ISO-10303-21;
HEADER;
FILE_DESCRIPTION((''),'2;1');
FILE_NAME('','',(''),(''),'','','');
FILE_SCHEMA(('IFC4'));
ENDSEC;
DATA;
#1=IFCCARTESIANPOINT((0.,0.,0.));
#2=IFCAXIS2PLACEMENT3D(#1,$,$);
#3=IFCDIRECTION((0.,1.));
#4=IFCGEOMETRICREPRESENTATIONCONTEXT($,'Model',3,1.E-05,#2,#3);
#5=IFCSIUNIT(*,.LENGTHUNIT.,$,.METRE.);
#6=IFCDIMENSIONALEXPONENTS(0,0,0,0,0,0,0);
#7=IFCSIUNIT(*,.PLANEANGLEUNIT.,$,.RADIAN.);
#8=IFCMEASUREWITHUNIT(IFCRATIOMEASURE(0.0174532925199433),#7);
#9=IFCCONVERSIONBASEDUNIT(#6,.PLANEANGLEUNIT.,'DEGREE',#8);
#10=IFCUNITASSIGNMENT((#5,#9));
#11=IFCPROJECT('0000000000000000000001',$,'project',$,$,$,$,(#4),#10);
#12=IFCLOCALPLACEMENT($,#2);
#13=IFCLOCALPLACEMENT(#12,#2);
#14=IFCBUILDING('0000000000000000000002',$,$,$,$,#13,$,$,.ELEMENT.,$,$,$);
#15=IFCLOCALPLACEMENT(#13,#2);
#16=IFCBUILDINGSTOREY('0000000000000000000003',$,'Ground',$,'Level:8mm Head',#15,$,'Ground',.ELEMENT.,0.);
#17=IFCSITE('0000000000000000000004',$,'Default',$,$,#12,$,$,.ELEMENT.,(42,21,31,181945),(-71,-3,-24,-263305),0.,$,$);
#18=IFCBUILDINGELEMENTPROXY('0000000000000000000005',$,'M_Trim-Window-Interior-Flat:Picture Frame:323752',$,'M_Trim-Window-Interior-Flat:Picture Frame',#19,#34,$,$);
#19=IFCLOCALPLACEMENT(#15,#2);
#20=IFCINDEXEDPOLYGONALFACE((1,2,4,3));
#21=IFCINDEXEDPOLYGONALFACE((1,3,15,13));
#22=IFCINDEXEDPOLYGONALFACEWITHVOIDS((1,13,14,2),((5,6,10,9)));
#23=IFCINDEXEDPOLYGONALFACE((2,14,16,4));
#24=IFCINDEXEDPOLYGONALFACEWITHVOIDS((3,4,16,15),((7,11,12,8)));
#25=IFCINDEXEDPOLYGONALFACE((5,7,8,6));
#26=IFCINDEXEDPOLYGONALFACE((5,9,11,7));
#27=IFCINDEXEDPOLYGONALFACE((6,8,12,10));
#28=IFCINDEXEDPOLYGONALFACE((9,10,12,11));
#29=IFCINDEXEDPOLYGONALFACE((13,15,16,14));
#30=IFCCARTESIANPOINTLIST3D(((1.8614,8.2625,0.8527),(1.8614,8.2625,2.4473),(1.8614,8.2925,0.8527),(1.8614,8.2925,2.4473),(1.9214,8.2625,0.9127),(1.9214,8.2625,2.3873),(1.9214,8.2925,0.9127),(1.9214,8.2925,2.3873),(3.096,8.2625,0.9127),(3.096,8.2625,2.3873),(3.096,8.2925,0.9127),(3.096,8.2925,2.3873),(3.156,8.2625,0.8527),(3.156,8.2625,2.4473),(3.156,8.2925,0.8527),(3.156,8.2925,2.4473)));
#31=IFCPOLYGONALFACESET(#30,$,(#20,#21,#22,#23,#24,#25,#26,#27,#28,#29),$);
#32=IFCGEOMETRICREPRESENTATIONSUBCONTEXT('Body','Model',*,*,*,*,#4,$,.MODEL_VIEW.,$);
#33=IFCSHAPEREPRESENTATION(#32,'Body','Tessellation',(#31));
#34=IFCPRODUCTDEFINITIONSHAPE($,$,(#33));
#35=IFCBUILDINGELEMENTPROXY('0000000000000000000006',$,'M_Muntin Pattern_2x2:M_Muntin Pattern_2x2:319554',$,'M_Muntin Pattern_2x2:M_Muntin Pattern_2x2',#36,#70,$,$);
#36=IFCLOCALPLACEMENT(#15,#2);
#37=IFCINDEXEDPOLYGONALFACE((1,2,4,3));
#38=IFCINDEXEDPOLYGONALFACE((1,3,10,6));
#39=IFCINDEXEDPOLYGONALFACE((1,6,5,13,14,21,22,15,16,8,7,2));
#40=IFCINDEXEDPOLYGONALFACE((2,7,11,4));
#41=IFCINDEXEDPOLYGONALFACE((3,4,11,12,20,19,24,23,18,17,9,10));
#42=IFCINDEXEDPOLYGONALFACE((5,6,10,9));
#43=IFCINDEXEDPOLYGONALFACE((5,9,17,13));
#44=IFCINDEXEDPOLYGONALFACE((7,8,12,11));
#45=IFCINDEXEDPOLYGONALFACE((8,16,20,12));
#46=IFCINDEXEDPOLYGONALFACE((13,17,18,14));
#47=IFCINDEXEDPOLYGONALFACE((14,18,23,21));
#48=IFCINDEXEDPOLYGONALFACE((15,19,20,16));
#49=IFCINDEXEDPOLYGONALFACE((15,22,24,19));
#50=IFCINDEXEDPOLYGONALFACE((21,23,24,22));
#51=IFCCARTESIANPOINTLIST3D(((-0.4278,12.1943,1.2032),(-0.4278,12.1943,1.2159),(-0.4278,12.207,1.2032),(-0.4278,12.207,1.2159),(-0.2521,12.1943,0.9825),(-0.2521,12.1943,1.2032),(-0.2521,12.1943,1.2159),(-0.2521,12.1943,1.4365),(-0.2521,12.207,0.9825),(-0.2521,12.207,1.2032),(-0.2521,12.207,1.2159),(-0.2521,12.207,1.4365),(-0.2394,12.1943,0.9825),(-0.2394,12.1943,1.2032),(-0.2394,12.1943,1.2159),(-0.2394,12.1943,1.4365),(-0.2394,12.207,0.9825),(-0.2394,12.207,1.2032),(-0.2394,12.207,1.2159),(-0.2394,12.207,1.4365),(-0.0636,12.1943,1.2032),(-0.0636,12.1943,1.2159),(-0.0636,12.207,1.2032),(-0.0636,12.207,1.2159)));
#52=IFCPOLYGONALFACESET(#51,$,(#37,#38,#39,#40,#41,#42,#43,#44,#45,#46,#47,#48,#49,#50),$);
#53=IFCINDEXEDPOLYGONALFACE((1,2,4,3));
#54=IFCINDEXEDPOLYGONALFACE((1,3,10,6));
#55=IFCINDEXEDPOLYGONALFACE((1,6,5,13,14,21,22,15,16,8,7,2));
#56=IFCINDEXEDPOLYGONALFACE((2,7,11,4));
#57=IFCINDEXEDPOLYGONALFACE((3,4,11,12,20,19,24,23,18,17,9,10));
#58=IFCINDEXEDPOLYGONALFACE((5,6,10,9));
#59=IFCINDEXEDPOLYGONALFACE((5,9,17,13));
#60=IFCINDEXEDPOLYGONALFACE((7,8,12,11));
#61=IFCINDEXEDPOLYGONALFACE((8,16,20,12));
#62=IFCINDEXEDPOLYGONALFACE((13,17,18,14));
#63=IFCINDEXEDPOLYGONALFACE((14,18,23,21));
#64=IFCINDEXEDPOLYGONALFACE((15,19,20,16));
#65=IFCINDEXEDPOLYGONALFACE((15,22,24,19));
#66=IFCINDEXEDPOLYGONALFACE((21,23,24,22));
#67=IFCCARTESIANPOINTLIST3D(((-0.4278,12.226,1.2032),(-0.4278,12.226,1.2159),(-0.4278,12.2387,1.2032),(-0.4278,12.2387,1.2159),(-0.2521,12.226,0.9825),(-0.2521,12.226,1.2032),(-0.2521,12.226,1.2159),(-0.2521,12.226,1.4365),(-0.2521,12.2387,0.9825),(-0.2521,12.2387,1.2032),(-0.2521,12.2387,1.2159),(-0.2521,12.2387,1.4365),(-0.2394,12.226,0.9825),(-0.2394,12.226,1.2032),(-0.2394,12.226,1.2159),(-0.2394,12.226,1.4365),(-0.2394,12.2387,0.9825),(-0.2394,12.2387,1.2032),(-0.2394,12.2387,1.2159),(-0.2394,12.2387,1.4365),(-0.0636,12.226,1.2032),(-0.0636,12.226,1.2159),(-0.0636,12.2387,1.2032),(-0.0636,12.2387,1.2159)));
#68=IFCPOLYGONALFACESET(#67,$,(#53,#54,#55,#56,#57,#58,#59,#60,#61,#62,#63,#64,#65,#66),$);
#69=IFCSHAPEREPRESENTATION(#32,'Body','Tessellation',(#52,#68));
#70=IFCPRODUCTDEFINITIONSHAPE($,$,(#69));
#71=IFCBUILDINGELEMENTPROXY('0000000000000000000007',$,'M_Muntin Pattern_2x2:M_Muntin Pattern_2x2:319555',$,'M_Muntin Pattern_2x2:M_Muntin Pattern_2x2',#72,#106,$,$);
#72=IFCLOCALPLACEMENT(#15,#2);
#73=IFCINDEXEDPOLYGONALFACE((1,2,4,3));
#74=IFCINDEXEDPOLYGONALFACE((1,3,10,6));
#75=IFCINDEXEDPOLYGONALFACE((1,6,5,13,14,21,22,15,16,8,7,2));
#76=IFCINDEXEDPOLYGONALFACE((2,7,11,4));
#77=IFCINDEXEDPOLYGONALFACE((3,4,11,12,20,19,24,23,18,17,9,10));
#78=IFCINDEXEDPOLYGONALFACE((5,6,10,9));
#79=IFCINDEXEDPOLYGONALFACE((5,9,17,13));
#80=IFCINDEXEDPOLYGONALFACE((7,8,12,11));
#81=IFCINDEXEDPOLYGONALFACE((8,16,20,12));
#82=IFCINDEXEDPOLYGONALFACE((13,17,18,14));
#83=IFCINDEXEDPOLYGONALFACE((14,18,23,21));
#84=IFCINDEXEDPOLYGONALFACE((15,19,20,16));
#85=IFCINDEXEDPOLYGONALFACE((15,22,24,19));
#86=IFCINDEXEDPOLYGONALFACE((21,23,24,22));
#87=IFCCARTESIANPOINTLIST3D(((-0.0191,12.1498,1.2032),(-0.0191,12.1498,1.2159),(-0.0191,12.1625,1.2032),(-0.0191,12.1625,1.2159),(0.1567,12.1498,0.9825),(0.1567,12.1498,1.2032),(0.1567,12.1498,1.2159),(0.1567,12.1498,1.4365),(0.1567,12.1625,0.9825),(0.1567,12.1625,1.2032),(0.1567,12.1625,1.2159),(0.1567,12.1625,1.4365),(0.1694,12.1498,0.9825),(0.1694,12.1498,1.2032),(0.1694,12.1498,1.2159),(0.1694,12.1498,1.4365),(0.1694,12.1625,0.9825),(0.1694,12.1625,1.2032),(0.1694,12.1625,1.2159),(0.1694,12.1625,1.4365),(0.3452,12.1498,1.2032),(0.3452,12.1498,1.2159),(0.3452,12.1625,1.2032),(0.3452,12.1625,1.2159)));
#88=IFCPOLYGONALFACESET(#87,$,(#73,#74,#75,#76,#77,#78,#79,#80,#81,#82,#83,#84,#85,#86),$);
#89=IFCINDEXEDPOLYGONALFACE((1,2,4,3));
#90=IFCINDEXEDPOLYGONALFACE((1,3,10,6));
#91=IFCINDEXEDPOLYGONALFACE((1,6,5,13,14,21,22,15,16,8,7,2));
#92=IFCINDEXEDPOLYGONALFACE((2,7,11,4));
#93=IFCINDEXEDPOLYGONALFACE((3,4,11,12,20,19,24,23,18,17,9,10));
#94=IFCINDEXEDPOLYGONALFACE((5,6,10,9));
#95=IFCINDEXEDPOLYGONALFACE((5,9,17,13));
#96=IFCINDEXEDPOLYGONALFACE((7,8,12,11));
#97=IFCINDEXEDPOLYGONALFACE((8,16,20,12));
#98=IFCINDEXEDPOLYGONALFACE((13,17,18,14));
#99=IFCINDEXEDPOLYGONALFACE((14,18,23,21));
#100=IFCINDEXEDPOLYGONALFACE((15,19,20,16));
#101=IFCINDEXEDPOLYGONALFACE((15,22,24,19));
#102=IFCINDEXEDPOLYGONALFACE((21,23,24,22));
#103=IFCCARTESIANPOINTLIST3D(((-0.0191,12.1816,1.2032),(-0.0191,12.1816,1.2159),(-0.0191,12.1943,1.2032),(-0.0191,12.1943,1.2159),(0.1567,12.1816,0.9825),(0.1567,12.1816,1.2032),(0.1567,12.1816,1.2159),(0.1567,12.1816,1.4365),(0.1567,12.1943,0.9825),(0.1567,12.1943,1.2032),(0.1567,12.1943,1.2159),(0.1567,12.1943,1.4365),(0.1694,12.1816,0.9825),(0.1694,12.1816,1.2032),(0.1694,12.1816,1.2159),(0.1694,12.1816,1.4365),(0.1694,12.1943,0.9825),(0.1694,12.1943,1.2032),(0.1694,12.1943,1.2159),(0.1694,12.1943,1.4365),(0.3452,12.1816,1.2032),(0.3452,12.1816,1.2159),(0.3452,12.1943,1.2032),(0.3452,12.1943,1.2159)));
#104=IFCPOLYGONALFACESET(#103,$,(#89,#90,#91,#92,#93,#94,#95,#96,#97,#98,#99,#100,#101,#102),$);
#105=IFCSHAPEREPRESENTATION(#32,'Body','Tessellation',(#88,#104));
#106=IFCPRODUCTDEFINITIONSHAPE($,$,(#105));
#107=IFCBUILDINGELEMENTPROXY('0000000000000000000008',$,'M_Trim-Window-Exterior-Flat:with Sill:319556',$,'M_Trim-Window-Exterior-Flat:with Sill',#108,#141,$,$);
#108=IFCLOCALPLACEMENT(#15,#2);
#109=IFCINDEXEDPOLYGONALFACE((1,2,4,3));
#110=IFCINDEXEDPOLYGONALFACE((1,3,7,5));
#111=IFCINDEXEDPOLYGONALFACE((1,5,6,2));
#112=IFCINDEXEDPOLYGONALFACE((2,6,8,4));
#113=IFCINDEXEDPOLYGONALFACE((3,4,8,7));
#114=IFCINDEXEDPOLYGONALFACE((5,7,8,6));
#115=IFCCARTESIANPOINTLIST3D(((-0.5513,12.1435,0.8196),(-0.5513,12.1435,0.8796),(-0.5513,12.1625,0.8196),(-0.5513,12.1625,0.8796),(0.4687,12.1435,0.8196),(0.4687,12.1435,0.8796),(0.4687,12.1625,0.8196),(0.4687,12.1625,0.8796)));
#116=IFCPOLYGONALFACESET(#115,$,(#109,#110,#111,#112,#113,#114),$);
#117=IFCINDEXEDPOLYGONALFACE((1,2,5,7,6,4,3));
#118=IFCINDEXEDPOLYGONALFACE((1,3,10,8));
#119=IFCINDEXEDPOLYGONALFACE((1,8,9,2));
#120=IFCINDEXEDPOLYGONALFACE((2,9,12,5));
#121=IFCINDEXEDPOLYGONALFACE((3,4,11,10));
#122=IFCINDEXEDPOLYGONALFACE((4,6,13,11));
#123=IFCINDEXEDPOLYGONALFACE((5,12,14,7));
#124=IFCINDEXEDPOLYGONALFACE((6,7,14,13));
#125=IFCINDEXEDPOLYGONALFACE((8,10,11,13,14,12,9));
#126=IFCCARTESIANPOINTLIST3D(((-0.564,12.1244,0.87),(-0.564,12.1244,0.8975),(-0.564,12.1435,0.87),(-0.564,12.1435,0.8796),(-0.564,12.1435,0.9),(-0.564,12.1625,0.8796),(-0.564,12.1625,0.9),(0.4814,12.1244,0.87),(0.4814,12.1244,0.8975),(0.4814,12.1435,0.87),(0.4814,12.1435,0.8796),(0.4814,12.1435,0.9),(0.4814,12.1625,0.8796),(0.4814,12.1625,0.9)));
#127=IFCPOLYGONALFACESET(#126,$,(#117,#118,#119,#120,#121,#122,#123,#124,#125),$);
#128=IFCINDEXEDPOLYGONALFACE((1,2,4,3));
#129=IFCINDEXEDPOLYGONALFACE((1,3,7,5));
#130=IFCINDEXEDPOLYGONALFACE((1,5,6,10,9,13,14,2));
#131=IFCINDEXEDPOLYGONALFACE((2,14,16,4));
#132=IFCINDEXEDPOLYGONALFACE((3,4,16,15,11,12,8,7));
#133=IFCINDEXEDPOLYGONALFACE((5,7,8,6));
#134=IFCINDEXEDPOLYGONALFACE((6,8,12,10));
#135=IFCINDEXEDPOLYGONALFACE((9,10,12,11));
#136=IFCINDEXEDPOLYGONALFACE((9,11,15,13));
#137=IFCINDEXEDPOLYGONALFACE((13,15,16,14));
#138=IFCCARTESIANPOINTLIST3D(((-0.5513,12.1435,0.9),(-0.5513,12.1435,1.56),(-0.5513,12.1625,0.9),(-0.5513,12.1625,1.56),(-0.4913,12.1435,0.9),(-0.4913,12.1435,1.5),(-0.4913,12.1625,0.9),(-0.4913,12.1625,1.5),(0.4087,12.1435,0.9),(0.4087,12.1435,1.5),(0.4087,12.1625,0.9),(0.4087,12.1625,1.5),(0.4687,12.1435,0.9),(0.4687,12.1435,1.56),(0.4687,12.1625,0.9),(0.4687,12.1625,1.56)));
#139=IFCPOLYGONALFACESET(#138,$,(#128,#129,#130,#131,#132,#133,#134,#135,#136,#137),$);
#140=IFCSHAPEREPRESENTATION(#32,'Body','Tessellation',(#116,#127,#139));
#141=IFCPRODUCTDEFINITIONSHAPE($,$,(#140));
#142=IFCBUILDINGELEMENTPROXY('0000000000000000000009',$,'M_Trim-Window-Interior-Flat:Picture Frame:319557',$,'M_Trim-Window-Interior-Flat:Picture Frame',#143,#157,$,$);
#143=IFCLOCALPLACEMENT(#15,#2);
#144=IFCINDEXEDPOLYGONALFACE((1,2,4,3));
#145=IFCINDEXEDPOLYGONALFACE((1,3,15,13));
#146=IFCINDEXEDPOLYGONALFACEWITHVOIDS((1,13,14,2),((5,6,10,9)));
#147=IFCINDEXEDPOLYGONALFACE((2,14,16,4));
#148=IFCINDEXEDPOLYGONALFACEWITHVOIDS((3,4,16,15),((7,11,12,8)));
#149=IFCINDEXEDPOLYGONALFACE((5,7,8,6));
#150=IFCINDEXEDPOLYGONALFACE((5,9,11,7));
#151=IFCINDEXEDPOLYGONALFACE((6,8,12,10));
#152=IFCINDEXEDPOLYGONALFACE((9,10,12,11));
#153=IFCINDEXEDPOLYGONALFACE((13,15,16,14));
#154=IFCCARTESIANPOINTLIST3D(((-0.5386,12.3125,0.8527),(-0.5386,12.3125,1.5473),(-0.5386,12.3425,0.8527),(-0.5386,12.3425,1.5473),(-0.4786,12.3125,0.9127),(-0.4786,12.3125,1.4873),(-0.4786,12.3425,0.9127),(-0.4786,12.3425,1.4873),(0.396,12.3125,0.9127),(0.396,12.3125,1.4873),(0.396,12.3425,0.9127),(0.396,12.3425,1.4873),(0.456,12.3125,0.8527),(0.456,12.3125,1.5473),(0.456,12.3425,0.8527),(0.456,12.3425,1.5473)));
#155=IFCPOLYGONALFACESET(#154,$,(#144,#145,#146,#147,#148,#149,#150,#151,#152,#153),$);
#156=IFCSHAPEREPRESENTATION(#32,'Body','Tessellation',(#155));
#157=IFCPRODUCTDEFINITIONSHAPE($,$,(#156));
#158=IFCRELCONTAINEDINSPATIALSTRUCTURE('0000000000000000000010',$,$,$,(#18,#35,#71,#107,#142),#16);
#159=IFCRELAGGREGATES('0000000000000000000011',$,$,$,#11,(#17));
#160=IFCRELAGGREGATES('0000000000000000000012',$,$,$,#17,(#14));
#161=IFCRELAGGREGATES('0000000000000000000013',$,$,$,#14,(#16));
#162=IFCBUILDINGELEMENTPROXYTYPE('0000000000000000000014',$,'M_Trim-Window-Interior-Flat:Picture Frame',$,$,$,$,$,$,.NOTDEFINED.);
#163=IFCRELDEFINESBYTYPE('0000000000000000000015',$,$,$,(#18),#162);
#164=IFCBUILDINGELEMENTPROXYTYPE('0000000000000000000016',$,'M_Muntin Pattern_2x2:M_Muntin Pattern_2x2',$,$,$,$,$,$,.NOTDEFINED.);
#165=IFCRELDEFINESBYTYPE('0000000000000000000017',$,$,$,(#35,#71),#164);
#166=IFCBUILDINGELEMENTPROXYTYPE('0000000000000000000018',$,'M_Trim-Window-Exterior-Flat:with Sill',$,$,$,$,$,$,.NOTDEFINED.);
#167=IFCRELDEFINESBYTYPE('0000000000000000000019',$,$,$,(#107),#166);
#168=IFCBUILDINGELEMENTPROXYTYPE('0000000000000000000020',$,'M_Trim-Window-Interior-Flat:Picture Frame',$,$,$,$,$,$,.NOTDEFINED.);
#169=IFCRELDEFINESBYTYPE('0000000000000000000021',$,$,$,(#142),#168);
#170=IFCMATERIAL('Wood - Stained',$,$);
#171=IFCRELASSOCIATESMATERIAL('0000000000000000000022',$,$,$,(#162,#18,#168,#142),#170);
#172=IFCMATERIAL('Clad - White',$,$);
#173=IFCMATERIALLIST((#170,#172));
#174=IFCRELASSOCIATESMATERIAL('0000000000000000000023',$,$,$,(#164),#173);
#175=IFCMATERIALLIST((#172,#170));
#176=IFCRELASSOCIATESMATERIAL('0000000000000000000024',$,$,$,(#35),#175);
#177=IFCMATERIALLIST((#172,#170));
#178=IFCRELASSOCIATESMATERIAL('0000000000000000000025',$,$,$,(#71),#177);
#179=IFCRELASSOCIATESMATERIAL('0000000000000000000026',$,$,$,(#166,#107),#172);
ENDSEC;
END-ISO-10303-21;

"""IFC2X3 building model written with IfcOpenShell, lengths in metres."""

from ifc_helpers import new_model, entity, si_unit, converted_unit, direction, frame, frame_2d, origin, place, context, subcontext, project, spatial, polyline, rectangle, outline, extrude, source, transform, mapped, material, material_list, type_object, type_shapes, element, save


model = new_model("IFC2X3")

# Units and contexts
model_context = context("Model", 3, precision=1e-05, world=origin(), true_north=direction((0.0, 1.0)))
body_context = subcontext(model_context, "Body", "Model", "MODEL_VIEW")
ifc_project = project(units=[si_unit("LENGTHUNIT", "METRE"), converted_unit("PLANEANGLEUNIT", "DEGREE", entity("IfcRatioMeasure", 0.0174532925199433), si_unit("PLANEANGLEUNIT", "RADIAN"), dimensions=[0, 0, 0, 0, 0, 0, 0])], contexts=[model_context])

# Site, building, storey
site_placement = place(None, origin())
site = spatial("IfcSite", under=ifc_project, at=site_placement, Name="Default", CompositionType="ELEMENT", RefLatitude=(42, 21, 31, 181945), RefLongitude=(-71, -3, -24, -263305), RefElevation=0.0)
building_placement = place(site_placement, origin())
building = spatial("IfcBuilding", under=site, at=building_placement, CompositionType="ELEMENT")
storey_placement = place(building_placement, origin())
storey = spatial("IfcBuildingStorey", under=building, at=storey_placement, Name="Ground", ObjectType="Level:8mm Head", LongName="Ground", CompositionType="ELEMENT", Elevation=0.0)

# Building element proxies
ifc_material_1 = material(Name="Clad - White")
ifc_material_2 = material(Name="Wood - Stained")
building_element_proxy_type_1 = type_object("IfcBuildingElementProxyType", Name="M_Trim-Window-Interior-Flat:Picture Frame", PredefinedType="NOTDEFINED", material=ifc_material_2)
shared_shape_1 = source(origin(), body_context, "Body", "SweptSolid", [
    extrude(outline(polyline([(-0.6473, -0.7973), (0.6473, -0.7973), (0.6473, 0.7973), (-0.6473, 0.7973), (-0.6473, -0.7973)]), holes=[polyline([(-0.5873, -0.7373), (-0.5873, 0.7373), (0.5873, 0.7373), (0.5873, -0.7373), (-0.5873, -0.7373)])]), frame((0.0, -0.75, 0.0), z_axis=(0.0, 0.0, 1.0), x_axis=(-1.0, 0.0, 0.0)), (0.0, 0.0, 1.0), 0.03),
])
type_shapes(building_element_proxy_type_1, [shared_shape_1])
for number, where, z_axis, x_axis, name in (
    (1, (2.5087, 8.2625, 2.4), (0.0, 1.0, 0.0), (-1.0, 0.0, 0.0), "M_Trim-Window-Interior-Flat:Picture Frame:323752"),
):
    element("IfcBuildingElementProxy", number, at=place(storey_placement, frame(where, z_axis=z_axis, x_axis=x_axis)), inside=storey, type_object=building_element_proxy_type_1, material=ifc_material_2, Name=name, ObjectType="M_Trim-Window-Interior-Flat:Picture Frame", context=body_context, shape_type="MappedRepresentation", body=[
        mapped(shared_shape_1, transform((0.0, 0.0, 0.0), scale=1.0)),
    ])
ifc_material_list_1 = material_list([ifc_material_1, ifc_material_2])
ifc_material_list_2 = material_list([ifc_material_2, ifc_material_1])
building_element_proxy_type_2 = type_object("IfcBuildingElementProxyType", Name="M_Muntin Pattern_2x2:M_Muntin Pattern_2x2", PredefinedType="NOTDEFINED", material=ifc_material_list_2)
shared_shape_2 = source(origin(), body_context, "Body", "SweptSolid", [
    extrude(outline(polyline([(0.0064, -0.0064), (0.227, -0.0064), (0.227, 0.0063), (0.0064, 0.0063), (0.0064, 0.1821), (-0.0063, 0.1821), (-0.0063, 0.0063), (-0.227, 0.0063), (-0.227, -0.0064), (-0.0063, -0.0064), (-0.0063, -0.1821), (0.0064, -0.1821), (0.0064, -0.0064)])), frame((0.0, 0.0095, 0.227), z_axis=(0.0, 1.0, 0.0), x_axis=(0.0, 0.0, 1.0)), (0.0, 0.0, 1.0), 0.0127),
    extrude(outline(polyline([(0.0064, -0.0064), (0.227, -0.0064), (0.227, 0.0063), (0.0064, 0.0063), (0.0064, 0.1821), (-0.0063, 0.1821), (-0.0063, 0.0063), (-0.227, 0.0063), (-0.227, -0.0064), (-0.0063, -0.0064), (-0.0063, -0.1821), (0.0064, -0.1821), (0.0064, -0.0064)])), frame((0.0, -0.0222, 0.227), z_axis=(0.0, 1.0, 0.0), x_axis=(0.0, 0.0, 1.0)), (0.0, 0.0, 1.0), 0.0127),
])
type_shapes(building_element_proxy_type_2, [shared_shape_2])
proxy_1_placement = place(storey_placement, frame((-0.2457, 12.2165, 0.9825), z_axis=(0.0, 0.0, 1.0), x_axis=(-1.0, 0.0, 0.0)))
element("IfcBuildingElementProxy", 2, at=proxy_1_placement, inside=storey, type_object=building_element_proxy_type_2, material=ifc_material_list_1, Name="M_Muntin Pattern_2x2:M_Muntin Pattern_2x2:319554", ObjectType="M_Muntin Pattern_2x2:M_Muntin Pattern_2x2", context=body_context, shape_type="MappedRepresentation", body=[
    mapped(shared_shape_2, transform((0.0, 0.0, 0.0), scale=1.0)),
])
ifc_material_list_3 = material_list([ifc_material_1, ifc_material_2])
proxy_2_placement = place(storey_placement, frame((0.163, 12.1721, 0.9825), z_axis=(0.0, 0.0, 1.0), x_axis=(-1.0, 0.0, 0.0)))
element("IfcBuildingElementProxy", 3, at=proxy_2_placement, inside=storey, type_object=building_element_proxy_type_2, material=ifc_material_list_3, Name="M_Muntin Pattern_2x2:M_Muntin Pattern_2x2:319555", ObjectType="M_Muntin Pattern_2x2:M_Muntin Pattern_2x2", context=body_context, shape_type="MappedRepresentation", body=[
    mapped(shared_shape_2, transform((0.0, 0.0, 0.0), scale=1.0)),
])
building_element_proxy_type_3 = type_object("IfcBuildingElementProxyType", Name="M_Trim-Window-Exterior-Flat:with Sill", PredefinedType="NOTDEFINED", material=ifc_material_1)
shared_shape_3 = source(origin(), body_context, "Body", "SweptSolid", [
    extrude(rectangle(XDim=1.02, YDim=0.06, at=frame_2d((0.0, 0.0), x_axis=(1.0, 0.0))), frame((0.0, -0.6504, 0.0), z_axis=(0.0, 0.0, 1.0), x_axis=(-1.0, 0.0, 0.0)), (0.0, 0.0, 1.0), 0.0191),
    extrude(outline(polyline([(-0.019, -0.0152), (0.0, -0.0152), (0.0, -0.0057), (0.019, -0.0057), (0.019, 0.0148), (0.0, 0.0148), (-0.019, 0.0123), (-0.019, -0.0152)])), frame((-0.5227, -0.6148, 0.019), z_axis=(1.0, 0.0, 0.0), x_axis=(0.0, 0.0, -1.0)), (0.0, 0.0, 1.0), 1.0454),
    extrude(outline(polyline([(-0.345, -0.51), (0.315, -0.51), (0.315, -0.45), (-0.285, -0.45), (-0.285, 0.45), (0.315, 0.45), (0.315, 0.51), (-0.345, 0.51), (-0.345, -0.51)])), frame((0.0, -0.285, 0.0), z_axis=(0.0, 0.0, 1.0), x_axis=(0.0, -1.0, 0.0)), (0.0, 0.0, 1.0), 0.0191),
])
type_shapes(building_element_proxy_type_3, [shared_shape_3])
proxy_3_placement = place(storey_placement, frame((-0.0413, 12.1625, 1.5), z_axis=(0.0, -1.0, 0.0), x_axis=(1.0, 0.0, 0.0)))
element("IfcBuildingElementProxy", 4, at=proxy_3_placement, inside=storey, type_object=building_element_proxy_type_3, material=ifc_material_1, Name="M_Trim-Window-Exterior-Flat:with Sill:319556", ObjectType="M_Trim-Window-Exterior-Flat:with Sill", context=body_context, shape_type="MappedRepresentation", body=[
    mapped(shared_shape_3, transform((0.0, 0.0, 0.0), scale=1.0)),
])
building_element_proxy_type_4 = type_object("IfcBuildingElementProxyType", Name="M_Trim-Window-Interior-Flat:Picture Frame", PredefinedType="NOTDEFINED", material=ifc_material_2)
shared_shape_4 = source(origin(), body_context, "Body", "SweptSolid", [
    extrude(outline(polyline([(-0.4973, -0.3473), (0.4973, -0.3473), (0.4973, 0.3473), (-0.4973, 0.3473), (-0.4973, -0.3473)]), holes=[polyline([(-0.4373, -0.2873), (-0.4373, 0.2873), (0.4373, 0.2873), (0.4373, -0.2873), (-0.4373, -0.2873)])]), frame((0.0, -0.3, 0.0), z_axis=(0.0, 0.0, 1.0), x_axis=(-1.0, 0.0, 0.0)), (0.0, 0.0, 1.0), 0.03),
])
type_shapes(building_element_proxy_type_4, [shared_shape_4])
proxy_4_placement = place(storey_placement, frame((-0.0413, 12.3125, 1.5), z_axis=(0.0, 1.0, 0.0), x_axis=(-1.0, 0.0, 0.0)))
element("IfcBuildingElementProxy", 5, at=proxy_4_placement, inside=storey, type_object=building_element_proxy_type_4, material=ifc_material_2, Name="M_Trim-Window-Interior-Flat:Picture Frame:319557", ObjectType="M_Trim-Window-Interior-Flat:Picture Frame", context=body_context, shape_type="MappedRepresentation", body=[
    mapped(shared_shape_4, transform((0.0, 0.0, 0.0), scale=1.0)),
])

save(model, "model.ifc")
